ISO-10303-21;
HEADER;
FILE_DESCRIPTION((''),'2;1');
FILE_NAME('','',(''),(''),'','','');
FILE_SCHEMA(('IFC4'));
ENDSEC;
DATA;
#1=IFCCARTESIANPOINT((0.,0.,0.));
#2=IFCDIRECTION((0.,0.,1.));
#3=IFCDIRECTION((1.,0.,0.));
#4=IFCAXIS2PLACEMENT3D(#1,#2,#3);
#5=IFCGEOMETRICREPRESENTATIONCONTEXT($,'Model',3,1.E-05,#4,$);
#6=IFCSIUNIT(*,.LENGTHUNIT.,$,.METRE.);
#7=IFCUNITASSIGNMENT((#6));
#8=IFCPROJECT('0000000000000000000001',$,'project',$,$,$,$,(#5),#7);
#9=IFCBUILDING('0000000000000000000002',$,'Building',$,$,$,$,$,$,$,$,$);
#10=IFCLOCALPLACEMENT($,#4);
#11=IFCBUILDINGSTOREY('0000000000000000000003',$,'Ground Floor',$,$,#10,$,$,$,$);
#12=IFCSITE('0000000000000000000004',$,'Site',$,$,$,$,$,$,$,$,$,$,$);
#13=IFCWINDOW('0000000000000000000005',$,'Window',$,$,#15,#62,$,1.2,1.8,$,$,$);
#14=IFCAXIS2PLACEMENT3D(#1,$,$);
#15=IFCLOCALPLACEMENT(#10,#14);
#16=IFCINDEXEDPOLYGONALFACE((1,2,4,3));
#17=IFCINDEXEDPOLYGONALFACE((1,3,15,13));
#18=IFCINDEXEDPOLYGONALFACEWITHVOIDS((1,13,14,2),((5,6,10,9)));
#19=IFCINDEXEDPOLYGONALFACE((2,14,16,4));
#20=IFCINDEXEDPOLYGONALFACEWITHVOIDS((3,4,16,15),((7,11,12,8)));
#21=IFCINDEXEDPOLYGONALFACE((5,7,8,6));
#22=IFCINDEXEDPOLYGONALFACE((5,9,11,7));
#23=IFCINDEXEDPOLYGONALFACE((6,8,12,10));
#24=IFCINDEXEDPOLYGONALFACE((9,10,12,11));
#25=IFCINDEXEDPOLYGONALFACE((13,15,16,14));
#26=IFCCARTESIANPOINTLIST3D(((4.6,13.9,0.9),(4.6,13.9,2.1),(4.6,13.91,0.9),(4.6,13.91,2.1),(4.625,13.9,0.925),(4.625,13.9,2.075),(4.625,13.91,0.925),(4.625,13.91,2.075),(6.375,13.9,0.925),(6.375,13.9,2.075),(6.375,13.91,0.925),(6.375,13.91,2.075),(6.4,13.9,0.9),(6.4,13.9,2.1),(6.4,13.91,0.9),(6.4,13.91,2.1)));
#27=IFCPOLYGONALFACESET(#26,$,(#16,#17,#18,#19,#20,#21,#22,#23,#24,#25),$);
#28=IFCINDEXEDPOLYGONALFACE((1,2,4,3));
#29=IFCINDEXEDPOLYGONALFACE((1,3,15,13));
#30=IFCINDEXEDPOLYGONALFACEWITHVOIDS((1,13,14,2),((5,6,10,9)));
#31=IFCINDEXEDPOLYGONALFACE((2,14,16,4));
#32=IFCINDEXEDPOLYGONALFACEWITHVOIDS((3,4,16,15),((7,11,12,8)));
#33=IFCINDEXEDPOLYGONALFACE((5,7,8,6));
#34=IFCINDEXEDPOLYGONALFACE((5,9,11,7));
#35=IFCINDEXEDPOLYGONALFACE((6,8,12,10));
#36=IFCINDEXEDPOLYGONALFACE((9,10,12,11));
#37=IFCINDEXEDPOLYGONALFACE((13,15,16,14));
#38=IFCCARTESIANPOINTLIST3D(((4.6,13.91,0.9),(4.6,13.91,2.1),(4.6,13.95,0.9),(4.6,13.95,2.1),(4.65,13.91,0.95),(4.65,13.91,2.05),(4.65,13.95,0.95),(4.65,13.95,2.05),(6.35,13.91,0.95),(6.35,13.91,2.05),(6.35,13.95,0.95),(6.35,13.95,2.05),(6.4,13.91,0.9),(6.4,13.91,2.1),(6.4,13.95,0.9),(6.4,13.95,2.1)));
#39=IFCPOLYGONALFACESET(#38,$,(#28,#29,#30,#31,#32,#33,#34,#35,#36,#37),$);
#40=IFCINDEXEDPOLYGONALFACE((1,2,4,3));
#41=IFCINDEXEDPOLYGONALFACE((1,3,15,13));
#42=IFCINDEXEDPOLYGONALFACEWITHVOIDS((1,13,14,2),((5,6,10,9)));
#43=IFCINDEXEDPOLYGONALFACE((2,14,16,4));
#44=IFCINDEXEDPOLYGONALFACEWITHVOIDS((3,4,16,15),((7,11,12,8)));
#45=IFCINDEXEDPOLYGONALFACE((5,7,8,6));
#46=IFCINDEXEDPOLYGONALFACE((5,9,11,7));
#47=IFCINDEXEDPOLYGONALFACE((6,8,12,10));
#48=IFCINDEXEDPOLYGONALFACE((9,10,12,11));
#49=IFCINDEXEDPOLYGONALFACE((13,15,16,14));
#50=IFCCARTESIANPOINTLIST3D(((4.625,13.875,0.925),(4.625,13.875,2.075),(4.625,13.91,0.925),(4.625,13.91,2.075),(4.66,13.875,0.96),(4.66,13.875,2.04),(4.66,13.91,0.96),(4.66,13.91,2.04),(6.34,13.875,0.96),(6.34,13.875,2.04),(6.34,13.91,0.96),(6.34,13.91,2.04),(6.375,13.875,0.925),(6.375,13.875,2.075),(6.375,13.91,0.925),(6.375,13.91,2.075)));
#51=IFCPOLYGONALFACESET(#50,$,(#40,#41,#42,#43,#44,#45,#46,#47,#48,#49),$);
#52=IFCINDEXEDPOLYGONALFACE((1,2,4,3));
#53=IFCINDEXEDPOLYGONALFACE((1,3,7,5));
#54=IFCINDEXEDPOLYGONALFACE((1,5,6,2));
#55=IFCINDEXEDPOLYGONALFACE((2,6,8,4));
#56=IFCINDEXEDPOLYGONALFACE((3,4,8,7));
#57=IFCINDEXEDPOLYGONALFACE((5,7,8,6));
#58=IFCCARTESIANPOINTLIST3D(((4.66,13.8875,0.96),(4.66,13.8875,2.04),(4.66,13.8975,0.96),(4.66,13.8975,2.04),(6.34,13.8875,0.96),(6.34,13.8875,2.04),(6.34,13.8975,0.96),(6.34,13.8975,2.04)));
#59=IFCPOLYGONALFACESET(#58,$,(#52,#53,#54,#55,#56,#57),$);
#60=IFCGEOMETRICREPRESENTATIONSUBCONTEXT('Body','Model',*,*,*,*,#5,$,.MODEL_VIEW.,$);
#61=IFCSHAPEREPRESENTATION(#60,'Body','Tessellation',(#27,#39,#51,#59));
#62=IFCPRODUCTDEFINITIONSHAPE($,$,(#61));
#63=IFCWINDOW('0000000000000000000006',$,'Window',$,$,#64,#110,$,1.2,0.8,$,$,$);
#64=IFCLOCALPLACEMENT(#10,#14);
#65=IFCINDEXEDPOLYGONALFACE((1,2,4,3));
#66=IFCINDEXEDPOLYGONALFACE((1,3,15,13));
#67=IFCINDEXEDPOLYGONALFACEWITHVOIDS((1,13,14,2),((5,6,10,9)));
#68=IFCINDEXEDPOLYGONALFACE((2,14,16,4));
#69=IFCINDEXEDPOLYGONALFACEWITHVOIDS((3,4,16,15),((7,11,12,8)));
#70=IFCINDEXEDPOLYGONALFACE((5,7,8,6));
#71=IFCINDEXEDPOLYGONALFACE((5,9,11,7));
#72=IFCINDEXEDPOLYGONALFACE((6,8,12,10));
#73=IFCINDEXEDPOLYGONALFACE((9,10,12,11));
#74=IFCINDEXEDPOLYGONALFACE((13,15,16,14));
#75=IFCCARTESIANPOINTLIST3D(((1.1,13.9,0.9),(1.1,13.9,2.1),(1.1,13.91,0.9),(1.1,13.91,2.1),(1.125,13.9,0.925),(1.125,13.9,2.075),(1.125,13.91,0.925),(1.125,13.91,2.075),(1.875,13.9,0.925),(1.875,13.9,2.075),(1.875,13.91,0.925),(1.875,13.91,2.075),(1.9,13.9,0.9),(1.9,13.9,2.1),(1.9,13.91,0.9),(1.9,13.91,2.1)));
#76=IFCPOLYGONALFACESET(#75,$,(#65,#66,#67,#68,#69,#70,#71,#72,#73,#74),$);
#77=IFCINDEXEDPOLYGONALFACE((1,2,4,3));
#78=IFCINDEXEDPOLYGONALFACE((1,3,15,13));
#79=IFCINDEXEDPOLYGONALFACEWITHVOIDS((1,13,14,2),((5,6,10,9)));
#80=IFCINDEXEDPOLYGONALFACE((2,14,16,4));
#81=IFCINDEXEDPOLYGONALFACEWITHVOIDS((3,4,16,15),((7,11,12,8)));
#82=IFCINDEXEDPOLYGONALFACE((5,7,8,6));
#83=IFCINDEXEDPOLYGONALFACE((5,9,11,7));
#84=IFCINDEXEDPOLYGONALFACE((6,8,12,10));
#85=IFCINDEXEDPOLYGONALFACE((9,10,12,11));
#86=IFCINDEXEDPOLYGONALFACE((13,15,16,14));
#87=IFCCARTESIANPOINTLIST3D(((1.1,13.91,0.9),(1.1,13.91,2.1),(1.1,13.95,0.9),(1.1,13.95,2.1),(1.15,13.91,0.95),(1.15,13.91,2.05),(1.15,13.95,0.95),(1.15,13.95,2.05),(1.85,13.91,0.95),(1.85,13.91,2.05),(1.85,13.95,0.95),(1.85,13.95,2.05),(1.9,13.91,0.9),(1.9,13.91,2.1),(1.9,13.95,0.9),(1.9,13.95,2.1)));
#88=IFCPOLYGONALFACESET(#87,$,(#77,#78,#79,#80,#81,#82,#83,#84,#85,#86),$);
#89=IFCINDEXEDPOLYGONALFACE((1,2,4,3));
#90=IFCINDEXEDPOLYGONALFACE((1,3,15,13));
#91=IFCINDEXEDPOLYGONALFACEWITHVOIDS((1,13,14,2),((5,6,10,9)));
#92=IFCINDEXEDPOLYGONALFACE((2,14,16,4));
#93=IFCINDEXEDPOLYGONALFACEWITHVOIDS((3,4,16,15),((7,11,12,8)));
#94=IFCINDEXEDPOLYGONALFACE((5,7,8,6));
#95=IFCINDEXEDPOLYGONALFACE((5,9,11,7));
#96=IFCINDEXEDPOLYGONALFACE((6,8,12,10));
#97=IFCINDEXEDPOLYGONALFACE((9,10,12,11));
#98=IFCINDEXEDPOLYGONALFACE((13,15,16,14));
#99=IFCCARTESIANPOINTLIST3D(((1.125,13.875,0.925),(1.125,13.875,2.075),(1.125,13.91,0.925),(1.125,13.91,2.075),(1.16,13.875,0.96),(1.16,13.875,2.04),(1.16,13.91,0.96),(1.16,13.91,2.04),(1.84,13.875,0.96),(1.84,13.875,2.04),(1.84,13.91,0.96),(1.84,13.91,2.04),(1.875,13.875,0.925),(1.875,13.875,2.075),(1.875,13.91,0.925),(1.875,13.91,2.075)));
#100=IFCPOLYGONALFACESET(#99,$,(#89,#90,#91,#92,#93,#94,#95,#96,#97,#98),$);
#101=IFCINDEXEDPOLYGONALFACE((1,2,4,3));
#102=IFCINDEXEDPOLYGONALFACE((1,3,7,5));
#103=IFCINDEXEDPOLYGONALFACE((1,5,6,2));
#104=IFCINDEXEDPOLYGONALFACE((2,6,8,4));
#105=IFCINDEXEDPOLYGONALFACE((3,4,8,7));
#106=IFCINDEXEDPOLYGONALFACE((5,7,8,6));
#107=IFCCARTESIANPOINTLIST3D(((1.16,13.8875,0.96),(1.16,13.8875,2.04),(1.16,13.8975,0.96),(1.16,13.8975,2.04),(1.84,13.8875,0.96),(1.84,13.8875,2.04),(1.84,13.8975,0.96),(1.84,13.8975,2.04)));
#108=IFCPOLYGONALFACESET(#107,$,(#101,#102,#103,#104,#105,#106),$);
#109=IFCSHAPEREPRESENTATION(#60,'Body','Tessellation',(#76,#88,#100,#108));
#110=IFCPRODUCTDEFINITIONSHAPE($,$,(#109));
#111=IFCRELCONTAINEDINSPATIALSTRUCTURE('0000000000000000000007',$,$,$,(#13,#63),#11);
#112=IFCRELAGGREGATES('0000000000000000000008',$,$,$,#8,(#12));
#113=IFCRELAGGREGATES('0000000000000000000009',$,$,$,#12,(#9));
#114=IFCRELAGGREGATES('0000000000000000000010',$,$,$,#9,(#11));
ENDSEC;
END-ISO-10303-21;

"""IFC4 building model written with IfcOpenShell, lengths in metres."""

from ifc_helpers import new_model, si_unit, frame, origin_with_axes, place, context, subcontext, project, spatial, line, indexed_curve, outline, extrude, element, save


model = new_model("IFC4")

# Units and contexts
model_context = context("Model", 3, precision=1e-05, world=origin_with_axes())
body_context = subcontext(model_context, "Body", "Model", "MODEL_VIEW")
ifc_project = project(units=[si_unit("LENGTHUNIT", "METRE")], contexts=[model_context])

# Site, building, storey
site = spatial("IfcSite", under=ifc_project, Name="Site")
building = spatial("IfcBuilding", under=site, Name="Building")
storey_placement = place(None, origin_with_axes())
storey = spatial("IfcBuildingStorey", under=building, at=storey_placement, Name="Ground Floor")

# Windows
window_1_placement = place(storey_placement, frame((6.4, 14.0, 0.9), z_axis=(0.0, 0.0, 1.0), x_axis=(-1.0, 0.0, 0.0)))
element("IfcWindow", 1, at=window_1_placement, inside=storey, Name="Window", OverallHeight=1.2, OverallWidth=1.8, context=body_context, shape_type="SweptSolid", body=[
    extrude(outline(indexed_curve([(0.0, 0.0), (1.8, 0.0), (1.8, 1.2), (0.0, 1.2)], segments=[line(1, 2, 3, 4, 1)]), holes=[indexed_curve([(0.025, 0.025), (1.775, 0.025), (1.775, 1.175), (0.025, 1.175)], segments=[line(1, 2, 3, 4, 1)])]), frame((0.0, 0.09, 0.0), z_axis=(0.0, -1.0, 0.0), x_axis=(1.0, 0.0, 0.0)), (0.0, 0.0, -1.0), 0.01),
    extrude(outline(indexed_curve([(0.0, 0.0), (1.8, 0.0), (1.8, 1.2), (0.0, 1.2)], segments=[line(1, 2, 3, 4, 1)]), holes=[indexed_curve([(0.05, 0.05), (1.75, 0.05), (1.75, 1.15), (0.05, 1.15)], segments=[line(1, 2, 3, 4, 1)])]), frame((0.0, 0.05, 0.0), z_axis=(0.0, -1.0, 0.0), x_axis=(1.0, 0.0, 0.0)), (0.0, 0.0, -1.0), 0.04),
    extrude(outline(indexed_curve([(0.0, 0.0), (1.75, 0.0), (1.75, 1.15), (0.0, 1.15)], segments=[line(1, 2, 3, 4, 1)]), holes=[indexed_curve([(0.035, 0.035), (1.715, 0.035), (1.715, 1.115), (0.035, 1.115)], segments=[line(1, 2, 3, 4, 1)])]), frame((0.025, 0.09, 0.025), z_axis=(0.0, -1.0, 0.0), x_axis=(1.0, 0.0, 0.0)), (0.0, 0.0, -1.0), 0.035),
    extrude(outline(indexed_curve([(0.035, 0.035), (1.715, 0.035), (1.715, 1.115), (0.035, 1.115)], segments=[line(1, 2, 3, 4, 1)])), frame((0.025, 0.1025, 0.025), z_axis=(0.0, -1.0, 0.0), x_axis=(1.0, 0.0, 0.0)), (0.0, 0.0, -1.0), 0.01),
])
window_2_placement = place(storey_placement, frame((1.9, 14.0, 0.9), z_axis=(0.0, 0.0, 1.0), x_axis=(-1.0, 0.0, 0.0)))
element("IfcWindow", 2, at=window_2_placement, inside=storey, Name="Window", OverallHeight=1.2, OverallWidth=0.8, context=body_context, shape_type="SweptSolid", body=[
    extrude(outline(indexed_curve([(0.0, 0.0), (0.8, 0.0), (0.8, 1.2), (0.0, 1.2)], segments=[line(1, 2, 3, 4, 1)]), holes=[indexed_curve([(0.025, 0.025), (0.775, 0.025), (0.775, 1.175), (0.025, 1.175)], segments=[line(1, 2, 3, 4, 1)])]), frame((0.0, 0.09, 0.0), z_axis=(0.0, -1.0, 0.0), x_axis=(1.0, 0.0, 0.0)), (0.0, 0.0, -1.0), 0.01),
    extrude(outline(indexed_curve([(0.0, 0.0), (0.8, 0.0), (0.8, 1.2), (0.0, 1.2)], segments=[line(1, 2, 3, 4, 1)]), holes=[indexed_curve([(0.05, 0.05), (0.75, 0.05), (0.75, 1.15), (0.05, 1.15)], segments=[line(1, 2, 3, 4, 1)])]), frame((0.0, 0.05, 0.0), z_axis=(0.0, -1.0, 0.0), x_axis=(1.0, 0.0, 0.0)), (0.0, 0.0, -1.0), 0.04),
    extrude(outline(indexed_curve([(0.0, 0.0), (0.75, 0.0), (0.75, 1.15), (0.0, 1.15)], segments=[line(1, 2, 3, 4, 1)]), holes=[indexed_curve([(0.035, 0.035), (0.715, 0.035), (0.715, 1.115), (0.035, 1.115)], segments=[line(1, 2, 3, 4, 1)])]), frame((0.025, 0.09, 0.025), z_axis=(0.0, -1.0, 0.0), x_axis=(1.0, 0.0, 0.0)), (0.0, 0.0, -1.0), 0.035),
    extrude(outline(indexed_curve([(0.035, 0.035), (0.715, 0.035), (0.715, 1.115), (0.035, 1.115)], segments=[line(1, 2, 3, 4, 1)])), frame((0.025, 0.1025, 0.025), z_axis=(0.0, -1.0, 0.0), x_axis=(1.0, 0.0, 0.0)), (0.0, 0.0, -1.0), 0.01),
])

save(model, "model.ifc")
